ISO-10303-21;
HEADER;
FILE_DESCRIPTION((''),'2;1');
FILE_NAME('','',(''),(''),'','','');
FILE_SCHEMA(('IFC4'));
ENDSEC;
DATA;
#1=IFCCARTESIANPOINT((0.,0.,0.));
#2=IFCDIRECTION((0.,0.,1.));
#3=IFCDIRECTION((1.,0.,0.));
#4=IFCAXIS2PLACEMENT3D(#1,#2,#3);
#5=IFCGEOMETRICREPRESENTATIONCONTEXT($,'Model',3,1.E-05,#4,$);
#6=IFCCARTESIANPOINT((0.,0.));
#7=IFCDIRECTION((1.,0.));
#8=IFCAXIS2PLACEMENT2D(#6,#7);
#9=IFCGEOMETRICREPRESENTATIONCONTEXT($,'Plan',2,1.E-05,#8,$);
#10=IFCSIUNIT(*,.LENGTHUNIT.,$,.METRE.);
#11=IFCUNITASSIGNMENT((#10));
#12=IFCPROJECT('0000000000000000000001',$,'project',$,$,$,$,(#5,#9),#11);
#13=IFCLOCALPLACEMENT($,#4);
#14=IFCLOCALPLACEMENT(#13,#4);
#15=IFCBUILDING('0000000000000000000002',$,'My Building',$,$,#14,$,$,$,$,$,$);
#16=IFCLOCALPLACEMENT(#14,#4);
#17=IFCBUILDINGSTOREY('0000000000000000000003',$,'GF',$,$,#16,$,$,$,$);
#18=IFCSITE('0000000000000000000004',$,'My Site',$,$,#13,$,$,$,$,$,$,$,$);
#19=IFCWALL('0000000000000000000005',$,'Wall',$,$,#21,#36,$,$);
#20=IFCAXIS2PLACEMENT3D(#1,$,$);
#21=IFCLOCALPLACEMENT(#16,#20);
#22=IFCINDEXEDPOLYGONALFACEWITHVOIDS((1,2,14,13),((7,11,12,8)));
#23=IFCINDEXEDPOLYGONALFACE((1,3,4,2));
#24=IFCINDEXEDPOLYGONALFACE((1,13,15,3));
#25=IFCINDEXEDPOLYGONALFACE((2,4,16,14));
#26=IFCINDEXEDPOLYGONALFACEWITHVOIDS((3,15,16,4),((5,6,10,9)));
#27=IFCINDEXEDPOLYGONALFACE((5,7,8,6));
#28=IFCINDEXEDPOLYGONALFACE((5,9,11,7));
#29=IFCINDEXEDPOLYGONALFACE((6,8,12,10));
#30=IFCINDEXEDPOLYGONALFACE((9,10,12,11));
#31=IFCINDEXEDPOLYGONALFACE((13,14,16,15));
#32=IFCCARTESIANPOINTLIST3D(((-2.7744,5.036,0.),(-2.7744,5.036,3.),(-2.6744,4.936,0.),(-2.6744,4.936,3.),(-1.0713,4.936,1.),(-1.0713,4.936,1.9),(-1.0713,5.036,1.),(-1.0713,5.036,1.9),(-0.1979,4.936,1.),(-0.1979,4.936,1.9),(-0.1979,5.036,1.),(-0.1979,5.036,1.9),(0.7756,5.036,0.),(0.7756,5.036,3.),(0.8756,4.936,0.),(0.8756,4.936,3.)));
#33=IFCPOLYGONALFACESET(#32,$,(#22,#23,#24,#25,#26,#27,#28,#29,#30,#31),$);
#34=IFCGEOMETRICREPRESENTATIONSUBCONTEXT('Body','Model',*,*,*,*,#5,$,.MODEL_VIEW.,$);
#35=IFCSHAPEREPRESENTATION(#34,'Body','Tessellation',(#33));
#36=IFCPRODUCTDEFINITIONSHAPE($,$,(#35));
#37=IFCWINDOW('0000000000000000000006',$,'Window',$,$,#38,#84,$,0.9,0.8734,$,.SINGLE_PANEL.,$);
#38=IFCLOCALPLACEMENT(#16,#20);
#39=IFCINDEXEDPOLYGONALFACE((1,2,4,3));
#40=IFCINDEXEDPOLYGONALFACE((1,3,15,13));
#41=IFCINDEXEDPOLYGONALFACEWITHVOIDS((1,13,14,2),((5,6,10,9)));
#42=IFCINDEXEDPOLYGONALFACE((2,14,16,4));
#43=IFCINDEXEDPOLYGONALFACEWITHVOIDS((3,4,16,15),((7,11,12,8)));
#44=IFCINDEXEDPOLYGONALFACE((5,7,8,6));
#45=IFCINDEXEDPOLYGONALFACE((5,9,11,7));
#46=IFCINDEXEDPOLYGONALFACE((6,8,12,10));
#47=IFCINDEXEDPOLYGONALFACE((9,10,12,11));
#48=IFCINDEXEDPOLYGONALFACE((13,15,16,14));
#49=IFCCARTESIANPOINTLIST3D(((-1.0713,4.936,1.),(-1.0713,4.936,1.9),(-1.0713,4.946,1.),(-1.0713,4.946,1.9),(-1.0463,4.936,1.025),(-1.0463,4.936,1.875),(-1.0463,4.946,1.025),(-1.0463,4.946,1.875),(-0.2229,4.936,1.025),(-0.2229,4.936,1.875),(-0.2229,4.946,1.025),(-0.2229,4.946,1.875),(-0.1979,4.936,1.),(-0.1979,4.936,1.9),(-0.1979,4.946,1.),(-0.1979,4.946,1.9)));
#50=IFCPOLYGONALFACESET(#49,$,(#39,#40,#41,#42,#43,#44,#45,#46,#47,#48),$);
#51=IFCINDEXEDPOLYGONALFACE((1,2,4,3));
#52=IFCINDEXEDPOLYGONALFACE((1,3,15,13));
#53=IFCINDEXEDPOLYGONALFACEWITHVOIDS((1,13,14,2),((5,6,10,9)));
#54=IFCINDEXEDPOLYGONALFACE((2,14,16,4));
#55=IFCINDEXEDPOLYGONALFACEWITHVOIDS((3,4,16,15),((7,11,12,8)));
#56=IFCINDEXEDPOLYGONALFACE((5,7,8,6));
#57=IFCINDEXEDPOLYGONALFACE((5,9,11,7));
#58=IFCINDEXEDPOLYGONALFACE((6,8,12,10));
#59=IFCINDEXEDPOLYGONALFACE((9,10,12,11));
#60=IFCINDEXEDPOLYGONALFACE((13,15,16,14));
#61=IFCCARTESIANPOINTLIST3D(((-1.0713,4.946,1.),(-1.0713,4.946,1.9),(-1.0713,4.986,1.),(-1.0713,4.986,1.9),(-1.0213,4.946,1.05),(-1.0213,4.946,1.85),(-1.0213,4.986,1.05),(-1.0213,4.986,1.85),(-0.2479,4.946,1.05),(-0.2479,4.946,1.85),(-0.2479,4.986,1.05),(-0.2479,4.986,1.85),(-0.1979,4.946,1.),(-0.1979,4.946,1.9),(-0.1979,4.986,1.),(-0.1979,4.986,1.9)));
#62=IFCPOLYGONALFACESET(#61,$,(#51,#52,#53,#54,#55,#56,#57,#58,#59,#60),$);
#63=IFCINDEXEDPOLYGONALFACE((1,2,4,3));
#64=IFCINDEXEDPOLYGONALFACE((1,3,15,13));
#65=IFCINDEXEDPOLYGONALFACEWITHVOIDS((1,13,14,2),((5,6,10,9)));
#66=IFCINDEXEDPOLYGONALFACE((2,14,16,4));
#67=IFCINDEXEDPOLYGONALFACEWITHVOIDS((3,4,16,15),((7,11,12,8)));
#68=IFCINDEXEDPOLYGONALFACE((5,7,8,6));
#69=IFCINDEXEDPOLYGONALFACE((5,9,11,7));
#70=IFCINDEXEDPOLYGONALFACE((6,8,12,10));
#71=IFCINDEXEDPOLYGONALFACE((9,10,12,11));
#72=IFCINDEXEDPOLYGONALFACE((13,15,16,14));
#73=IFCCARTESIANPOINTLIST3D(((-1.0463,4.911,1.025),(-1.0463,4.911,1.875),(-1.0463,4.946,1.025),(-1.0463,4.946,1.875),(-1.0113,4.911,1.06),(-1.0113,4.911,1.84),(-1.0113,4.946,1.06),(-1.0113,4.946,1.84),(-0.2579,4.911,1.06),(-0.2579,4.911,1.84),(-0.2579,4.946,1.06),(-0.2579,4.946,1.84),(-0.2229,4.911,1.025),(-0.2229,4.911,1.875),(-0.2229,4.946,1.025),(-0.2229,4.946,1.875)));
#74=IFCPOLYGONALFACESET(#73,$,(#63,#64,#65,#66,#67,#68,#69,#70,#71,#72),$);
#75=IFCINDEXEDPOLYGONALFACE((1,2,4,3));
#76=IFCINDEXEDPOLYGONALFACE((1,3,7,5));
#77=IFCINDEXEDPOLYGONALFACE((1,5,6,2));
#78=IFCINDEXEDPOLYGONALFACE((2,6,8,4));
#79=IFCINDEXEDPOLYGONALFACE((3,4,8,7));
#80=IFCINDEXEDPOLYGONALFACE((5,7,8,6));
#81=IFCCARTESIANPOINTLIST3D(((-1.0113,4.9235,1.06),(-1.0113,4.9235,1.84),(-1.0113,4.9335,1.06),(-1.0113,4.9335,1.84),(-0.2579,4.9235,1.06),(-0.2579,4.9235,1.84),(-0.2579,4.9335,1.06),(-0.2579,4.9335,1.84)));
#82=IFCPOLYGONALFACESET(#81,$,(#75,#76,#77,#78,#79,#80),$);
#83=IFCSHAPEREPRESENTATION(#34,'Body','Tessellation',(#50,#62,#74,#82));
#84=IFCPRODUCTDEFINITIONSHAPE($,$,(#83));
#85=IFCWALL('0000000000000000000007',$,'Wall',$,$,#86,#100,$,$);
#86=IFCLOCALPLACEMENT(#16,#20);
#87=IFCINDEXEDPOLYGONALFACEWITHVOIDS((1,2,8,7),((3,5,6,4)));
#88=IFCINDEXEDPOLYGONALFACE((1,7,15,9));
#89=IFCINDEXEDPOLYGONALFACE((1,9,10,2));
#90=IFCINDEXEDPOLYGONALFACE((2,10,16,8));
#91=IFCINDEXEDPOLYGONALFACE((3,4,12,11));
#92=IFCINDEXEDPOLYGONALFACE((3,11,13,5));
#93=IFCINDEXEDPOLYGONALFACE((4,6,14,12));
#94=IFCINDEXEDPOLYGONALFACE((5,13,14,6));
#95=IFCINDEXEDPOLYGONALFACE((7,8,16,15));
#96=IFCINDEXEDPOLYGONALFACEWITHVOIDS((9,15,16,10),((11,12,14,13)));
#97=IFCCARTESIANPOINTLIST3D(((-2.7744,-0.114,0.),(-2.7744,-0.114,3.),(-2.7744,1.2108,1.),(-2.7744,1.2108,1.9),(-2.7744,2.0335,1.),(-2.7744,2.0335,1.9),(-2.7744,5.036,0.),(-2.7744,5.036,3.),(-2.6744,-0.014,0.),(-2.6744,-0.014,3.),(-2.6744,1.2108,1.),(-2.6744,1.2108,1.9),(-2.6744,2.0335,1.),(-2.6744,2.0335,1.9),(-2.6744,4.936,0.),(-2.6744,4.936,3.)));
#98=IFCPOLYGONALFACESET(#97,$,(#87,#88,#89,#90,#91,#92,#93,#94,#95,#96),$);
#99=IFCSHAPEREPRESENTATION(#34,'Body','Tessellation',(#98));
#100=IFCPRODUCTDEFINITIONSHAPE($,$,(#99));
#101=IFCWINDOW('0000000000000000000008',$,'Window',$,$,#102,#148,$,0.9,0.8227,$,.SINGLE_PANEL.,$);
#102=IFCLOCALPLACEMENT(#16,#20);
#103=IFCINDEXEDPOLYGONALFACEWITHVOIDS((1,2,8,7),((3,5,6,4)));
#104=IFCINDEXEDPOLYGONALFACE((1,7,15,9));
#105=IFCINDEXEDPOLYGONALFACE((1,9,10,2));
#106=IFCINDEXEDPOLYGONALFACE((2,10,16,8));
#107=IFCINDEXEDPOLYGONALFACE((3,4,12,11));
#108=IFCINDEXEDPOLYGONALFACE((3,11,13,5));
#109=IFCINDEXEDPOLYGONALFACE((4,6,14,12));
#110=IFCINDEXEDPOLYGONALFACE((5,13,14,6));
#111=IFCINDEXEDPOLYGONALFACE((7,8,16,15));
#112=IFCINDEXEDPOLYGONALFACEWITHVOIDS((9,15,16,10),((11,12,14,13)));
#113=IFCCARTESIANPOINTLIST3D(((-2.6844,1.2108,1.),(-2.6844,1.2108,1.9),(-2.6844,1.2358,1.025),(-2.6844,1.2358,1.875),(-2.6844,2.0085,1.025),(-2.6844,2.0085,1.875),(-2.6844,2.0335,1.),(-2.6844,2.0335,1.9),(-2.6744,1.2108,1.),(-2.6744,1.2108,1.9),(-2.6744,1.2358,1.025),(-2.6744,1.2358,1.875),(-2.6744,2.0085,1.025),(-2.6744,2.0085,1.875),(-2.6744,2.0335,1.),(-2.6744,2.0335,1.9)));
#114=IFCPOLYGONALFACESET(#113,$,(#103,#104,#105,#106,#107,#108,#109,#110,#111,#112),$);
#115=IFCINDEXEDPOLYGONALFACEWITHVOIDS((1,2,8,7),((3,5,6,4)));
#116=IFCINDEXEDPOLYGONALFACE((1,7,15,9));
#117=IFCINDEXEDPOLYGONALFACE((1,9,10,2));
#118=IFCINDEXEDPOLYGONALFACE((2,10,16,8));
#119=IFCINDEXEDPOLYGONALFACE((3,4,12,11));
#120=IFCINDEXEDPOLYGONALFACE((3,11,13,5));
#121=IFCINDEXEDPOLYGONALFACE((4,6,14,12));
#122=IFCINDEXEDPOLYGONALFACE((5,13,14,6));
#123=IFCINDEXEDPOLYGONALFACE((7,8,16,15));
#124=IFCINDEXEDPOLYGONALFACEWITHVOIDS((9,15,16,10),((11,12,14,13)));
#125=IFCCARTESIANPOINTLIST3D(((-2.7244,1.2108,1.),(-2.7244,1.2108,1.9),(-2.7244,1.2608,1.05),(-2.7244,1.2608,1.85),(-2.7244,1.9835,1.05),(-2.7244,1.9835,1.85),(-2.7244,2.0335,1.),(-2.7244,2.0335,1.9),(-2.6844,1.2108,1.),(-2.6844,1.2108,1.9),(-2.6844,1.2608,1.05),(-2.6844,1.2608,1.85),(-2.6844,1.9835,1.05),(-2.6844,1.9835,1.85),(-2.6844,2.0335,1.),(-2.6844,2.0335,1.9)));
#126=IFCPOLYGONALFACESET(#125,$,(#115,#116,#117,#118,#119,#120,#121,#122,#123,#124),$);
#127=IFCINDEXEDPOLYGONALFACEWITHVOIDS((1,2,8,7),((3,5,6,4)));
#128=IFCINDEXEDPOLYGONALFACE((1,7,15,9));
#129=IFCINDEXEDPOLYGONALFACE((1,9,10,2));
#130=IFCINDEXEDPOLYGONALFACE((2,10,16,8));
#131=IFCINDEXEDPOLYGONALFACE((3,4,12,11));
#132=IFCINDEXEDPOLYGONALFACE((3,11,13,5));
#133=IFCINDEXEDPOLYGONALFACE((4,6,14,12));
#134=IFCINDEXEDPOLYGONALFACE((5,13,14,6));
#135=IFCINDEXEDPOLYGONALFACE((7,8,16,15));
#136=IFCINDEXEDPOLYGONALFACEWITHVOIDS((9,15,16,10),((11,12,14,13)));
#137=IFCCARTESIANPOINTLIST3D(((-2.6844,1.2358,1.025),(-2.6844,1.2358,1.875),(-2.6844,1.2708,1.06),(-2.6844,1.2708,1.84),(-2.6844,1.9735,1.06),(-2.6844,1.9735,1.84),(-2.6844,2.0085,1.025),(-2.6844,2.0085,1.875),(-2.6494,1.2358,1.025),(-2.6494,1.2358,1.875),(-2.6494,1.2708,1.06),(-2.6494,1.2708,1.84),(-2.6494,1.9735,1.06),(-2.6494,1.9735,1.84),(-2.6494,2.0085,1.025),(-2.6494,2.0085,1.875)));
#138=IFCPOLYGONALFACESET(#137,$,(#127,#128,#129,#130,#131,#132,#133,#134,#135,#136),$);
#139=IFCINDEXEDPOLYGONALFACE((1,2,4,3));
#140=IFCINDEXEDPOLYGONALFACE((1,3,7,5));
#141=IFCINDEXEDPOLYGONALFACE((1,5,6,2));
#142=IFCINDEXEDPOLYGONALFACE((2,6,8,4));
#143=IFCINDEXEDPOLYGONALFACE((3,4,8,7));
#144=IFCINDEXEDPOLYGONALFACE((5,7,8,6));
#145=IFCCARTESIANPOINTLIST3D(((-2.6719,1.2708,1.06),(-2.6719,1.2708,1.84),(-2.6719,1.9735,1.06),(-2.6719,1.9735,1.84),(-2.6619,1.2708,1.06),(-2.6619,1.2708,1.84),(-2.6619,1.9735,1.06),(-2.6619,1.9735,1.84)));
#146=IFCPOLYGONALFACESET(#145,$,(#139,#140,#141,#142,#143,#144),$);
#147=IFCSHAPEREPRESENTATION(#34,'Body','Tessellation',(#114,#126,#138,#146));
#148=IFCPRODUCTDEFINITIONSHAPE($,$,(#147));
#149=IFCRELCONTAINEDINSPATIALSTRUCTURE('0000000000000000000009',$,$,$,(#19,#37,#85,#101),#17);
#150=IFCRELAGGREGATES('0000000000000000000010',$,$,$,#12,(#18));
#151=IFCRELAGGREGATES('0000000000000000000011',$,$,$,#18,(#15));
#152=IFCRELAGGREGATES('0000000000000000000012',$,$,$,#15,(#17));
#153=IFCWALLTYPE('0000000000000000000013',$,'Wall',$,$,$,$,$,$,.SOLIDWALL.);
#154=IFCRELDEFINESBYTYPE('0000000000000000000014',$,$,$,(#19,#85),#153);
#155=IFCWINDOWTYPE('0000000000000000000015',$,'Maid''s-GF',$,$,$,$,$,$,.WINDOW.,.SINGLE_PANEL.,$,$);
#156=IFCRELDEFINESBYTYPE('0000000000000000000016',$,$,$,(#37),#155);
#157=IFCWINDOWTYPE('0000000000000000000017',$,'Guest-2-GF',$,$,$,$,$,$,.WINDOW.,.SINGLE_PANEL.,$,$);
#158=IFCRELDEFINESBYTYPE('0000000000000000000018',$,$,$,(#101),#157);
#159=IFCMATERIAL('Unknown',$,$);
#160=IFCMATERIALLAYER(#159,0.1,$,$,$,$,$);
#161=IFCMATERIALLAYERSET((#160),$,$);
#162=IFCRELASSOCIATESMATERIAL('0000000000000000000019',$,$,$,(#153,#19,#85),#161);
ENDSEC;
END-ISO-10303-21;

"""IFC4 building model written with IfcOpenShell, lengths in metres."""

from ifc_helpers import new_model, entity, si_unit, frame, origin_with_axes, origin_2d_with_axis, place, context, subcontext, project, spatial, line, indexed_curve, outline, extrude, shape, source, transform, mapped, material, layer, layer_set, layer_usage, type_object, type_shapes, element, fill, save


model = new_model("IFC4")

# Units and contexts
model_context = context("Model", 3, precision=1e-05, world=origin_with_axes())
plan_context = context("Plan", 2, precision=1e-05, world=origin_2d_with_axis())
body_context_1 = subcontext(model_context, "Body", "Model", "MODEL_VIEW")
body_context_2 = subcontext(plan_context, "Body", "Plan", "PLAN_VIEW")
ifc_project = project(units=[si_unit("LENGTHUNIT", "METRE")], contexts=[model_context, plan_context])

# Site, building, storey
site_placement = place(None, origin_with_axes())
site = spatial("IfcSite", under=ifc_project, at=site_placement, Name="My Site")
building_placement = place(site_placement, origin_with_axes())
building = spatial("IfcBuilding", under=site, at=building_placement, Name="My Building")
storey_placement = place(building_placement, origin_with_axes())
storey = spatial("IfcBuildingStorey", under=building, at=storey_placement, Name="GF")

# Shared definitions
ifc_material_1 = material(Name="Unknown")

# Shared definitions
ifc_layer_1 = layer(ifc_material_1, 0.1)
ifc_layer_set_1 = layer_set([ifc_layer_1])
wall_type = type_object("IfcWallType", Name="Wall", PredefinedType="SOLIDWALL", material=ifc_layer_set_1)

# Walls, openings, windows
ifc_layer_usage_1 = layer_usage(ifc_layer_set_1, "AXIS2", "POSITIVE", 0.0)
wall_1_placement = place(storey_placement, frame((0.7756, 5.036, 0.0), z_axis=(0.0, 0.0, 1.0), x_axis=(-1.0, 0.0, 0.0)))
wall_1 = element("IfcWall", 1, at=wall_1_placement, inside=storey, type_object=wall_type, material=ifc_layer_usage_1, Name="Wall", context=body_context_1, shape_type="SweptSolid", body=[
    extrude(outline(indexed_curve([(0.0, 0.0), (-0.1, 0.1), (3.45, 0.1), (3.55, 0.0)], segments=[line(1, 2, 3, 4, 1)])), origin_with_axes(), (0.0, 0.0, 1.0), 3.0),
])
shared_shape_1 = source(origin_with_axes(), body_context_1, "Body", "SweptSolid", [
    extrude(outline(indexed_curve([(0.0, 0.0), (0.8734, 0.0), (0.8734, 0.9), (0.0, 0.9)], segments=[line(1, 2, 3, 4, 1)])), frame((0.0, -0.6, 0.0), z_axis=(0.0, -1.0, 0.0), x_axis=(1.0, 0.0, 0.0)), (0.0, 0.0, -1.0), 1.2),
])
opening_1_placement = place(wall_1_placement, frame((0.9735, 0.0, 1.0), z_axis=(0.0, 0.0, 1.0), x_axis=(1.0, -0.000001, 0.0)))
opening_1 = element("IfcOpeningElement", 2, at=opening_1_placement, cuts=wall_1, PredefinedType="OPENING", context=body_context_1, shape_type="MappedRepresentation", body=[
    mapped(shared_shape_1, transform((0.0, 0.0, 0.0), x_axis=(1.0, 0.0, 0.0), y_axis=(0.0, 1.0, 0.0), z_axis=(0.0, 0.0, 1.0), scale=1.0)),
])
window_type_1 = type_object("IfcWindowType", Name="Maid's-GF", PartitioningType="SINGLE_PANEL", PredefinedType="WINDOW")
shared_shape_2 = source(origin_with_axes(), body_context_1, "Body", "SweptSolid", [
    extrude(outline(indexed_curve([(0.0, 0.0), (0.8734, 0.0), (0.8734, 0.9), (0.0, 0.9)], segments=[line(1, 2, 3, 4, 1)]), holes=[indexed_curve([(0.025, 0.025), (0.8484, 0.025), (0.8484, 0.875), (0.025, 0.875)], segments=[line(1, 2, 3, 4, 1)])]), frame((0.0, 0.09, 0.0), z_axis=(0.0, -1.0, 0.0), x_axis=(1.0, 0.0, 0.0)), (0.0, 0.0, -1.0), 0.01),
    extrude(outline(indexed_curve([(0.0, 0.0), (0.8734, 0.0), (0.8734, 0.9), (0.0, 0.9)], segments=[line(1, 2, 3, 4, 1)]), holes=[indexed_curve([(0.05, 0.05), (0.8234, 0.05), (0.8234, 0.85), (0.05, 0.85)], segments=[line(1, 2, 3, 4, 1)])]), frame((0.0, 0.05, 0.0), z_axis=(0.0, -1.0, 0.0), x_axis=(1.0, 0.0, 0.0)), (0.0, 0.0, -1.0), 0.04),
    extrude(outline(indexed_curve([(0.0, 0.0), (0.8234, 0.0), (0.8234, 0.85), (0.0, 0.85)], segments=[line(1, 2, 3, 4, 1)]), holes=[indexed_curve([(0.035, 0.035), (0.7884, 0.035), (0.7884, 0.815), (0.035, 0.815)], segments=[line(1, 2, 3, 4, 1)])]), frame((0.025, 0.09, 0.025), z_axis=(0.0, -1.0, 0.0), x_axis=(1.0, 0.0, 0.0)), (0.0, 0.0, -1.0), 0.035),
    extrude(outline(indexed_curve([(0.035, 0.035), (0.7884, 0.035), (0.7884, 0.815), (0.035, 0.815)], segments=[line(1, 2, 3, 4, 1)])), frame((0.025, 0.1025, 0.025), z_axis=(0.0, -1.0, 0.0), x_axis=(1.0, 0.0, 0.0)), (0.0, 0.0, -1.0), 0.01),
])
shared_shape_3 = source(origin_with_axes(), body_context_2, "Body", "Curve2D", [
    entity("IfcIndexedPolyCurve", entity("IfcCartesianPointList2D", [[0.05, 0.05], [0.8234, 0.05]])),
    entity("IfcIndexedPolyCurve", entity("IfcCartesianPointList2D", [[0.0, 0.1], [0.025, 0.1], [0.025, 0.09], [0.05, 0.09], [0.05, 0.05], [0.0, 0.05]]), [entity("IfcLineIndex", [1, 2, 3, 4, 5, 6, 1])]),
    entity("IfcIndexedPolyCurve", entity("IfcCartesianPointList2D", [[0.8734, 0.1], [0.8484, 0.1], [0.8484, 0.09], [0.8234, 0.09], [0.8234, 0.05], [0.8734, 0.05]]), [entity("IfcLineIndex", [1, 2, 3, 4, 5, 6, 1])]),
    entity("IfcIndexedPolyCurve", entity("IfcCartesianPointList2D", [[0.025, 0.09], [0.06, 0.09], [0.06, 0.125], [0.025, 0.125]]), [entity("IfcLineIndex", [1, 2, 3, 4, 1])]),
    entity("IfcIndexedPolyCurve", entity("IfcCartesianPointList2D", [[0.8484, 0.09], [0.8134, 0.09], [0.8134, 0.125], [0.8484, 0.125]]), [entity("IfcLineIndex", [1, 2, 3, 4, 1])]),
    entity("IfcIndexedPolyCurve", entity("IfcCartesianPointList2D", [[0.06, 0.09], [0.8134, 0.09]])),
    entity("IfcIndexedPolyCurve", entity("IfcCartesianPointList2D", [[0.06, 0.125], [0.8134, 0.125]])),
    entity("IfcIndexedPolyCurve", entity("IfcCartesianPointList2D", [[0.06, 0.1075], [0.8134, 0.1075]])),
])
type_shapes(window_type_1, [shared_shape_2, shared_shape_3])
window_1_placement = place(opening_1_placement, frame((0.0, 0.0, 0.0), z_axis=(0.0, 0.0, 1.0), x_axis=(1.0, 0.0, 0.0)))
window_1 = element("IfcWindow", 3, at=window_1_placement, inside=storey, type_object=window_type_1, Name="Window", OverallHeight=0.9, OverallWidth=0.8734, PartitioningType="SINGLE_PANEL", shapes=[
    shape(body_context_1, "Body", "MappedRepresentation", [mapped(shared_shape_2, transform((0.0, 0.0, 0.0), x_axis=(1.0, 0.0, 0.0), y_axis=(0.0, 1.0, 0.0), z_axis=(0.0, 0.0, 1.0), scale=1.0))]),
    shape(body_context_2, "Body", "MappedRepresentation", [mapped(shared_shape_3, transform((0.0, 0.0, 0.0), x_axis=(1.0, 0.0, 0.0), y_axis=(0.0, 1.0, 0.0), z_axis=(0.0, 0.0, 1.0), scale=1.0))]),
])
fill(opening_1, window_1)
ifc_layer_usage_2 = layer_usage(ifc_layer_set_1, "AXIS2", "POSITIVE", 0.0)
wall_2_placement = place(storey_placement, frame((-2.7744, 5.036, 0.0), z_axis=(0.0, 0.0, 1.0), x_axis=(0.0, -1.0, 0.0)))
wall_2 = element("IfcWall", 4, at=wall_2_placement, inside=storey, type_object=wall_type, material=ifc_layer_usage_2, Name="Wall", context=body_context_1, shape_type="SweptSolid", body=[
    extrude(outline(indexed_curve([(0.0, 0.0), (0.1, 0.1), (5.05, 0.1), (5.15, 0.0)], segments=[line(1, 2, 3, 4, 1)])), origin_with_axes(), (0.0, 0.0, 1.0), 3.0),
])
shared_shape_4 = source(origin_with_axes(), body_context_1, "Body", "SweptSolid", [
    extrude(outline(indexed_curve([(0.0, 0.0), (0.8227, 0.0), (0.8227, 0.9), (0.0, 0.9)], segments=[line(1, 2, 3, 4, 1)])), frame((0.0, -0.6, 0.0), z_axis=(0.0, -1.0, 0.0), x_axis=(1.0, 0.0, 0.0)), (0.0, 0.0, -1.0), 1.2),
])
opening_2_placement = place(wall_2_placement, frame((3.0025, 0.0, 1.0), z_axis=(0.0, 0.0, 1.0), x_axis=(1.0, 0.0, 0.0)))
opening_2 = element("IfcOpeningElement", 5, at=opening_2_placement, cuts=wall_2, PredefinedType="OPENING", context=body_context_1, shape_type="MappedRepresentation", body=[
    mapped(shared_shape_4, transform((0.0, 0.0, 0.0), x_axis=(1.0, 0.0, 0.0), y_axis=(0.0, 1.0, 0.0), z_axis=(0.0, 0.0, 1.0), scale=1.0)),
])
window_type_2 = type_object("IfcWindowType", Name="Guest-2-GF", PartitioningType="SINGLE_PANEL", PredefinedType="WINDOW")
shared_shape_5 = source(origin_with_axes(), body_context_1, "Body", "SweptSolid", [
    extrude(outline(indexed_curve([(0.0, 0.0), (0.8227, 0.0), (0.8227, 0.9), (0.0, 0.9)], segments=[line(1, 2, 3, 4, 1)]), holes=[indexed_curve([(0.025, 0.025), (0.7977, 0.025), (0.7977, 0.875), (0.025, 0.875)], segments=[line(1, 2, 3, 4, 1)])]), frame((0.0, 0.09, 0.0), z_axis=(0.0, -1.0, 0.0), x_axis=(1.0, 0.0, 0.0)), (0.0, 0.0, -1.0), 0.01),
    extrude(outline(indexed_curve([(0.0, 0.0), (0.8227, 0.0), (0.8227, 0.9), (0.0, 0.9)], segments=[line(1, 2, 3, 4, 1)]), holes=[indexed_curve([(0.05, 0.05), (0.7727, 0.05), (0.7727, 0.85), (0.05, 0.85)], segments=[line(1, 2, 3, 4, 1)])]), frame((0.0, 0.05, 0.0), z_axis=(0.0, -1.0, 0.0), x_axis=(1.0, 0.0, 0.0)), (0.0, 0.0, -1.0), 0.04),
    extrude(outline(indexed_curve([(0.0, 0.0), (0.7727, 0.0), (0.7727, 0.85), (0.0, 0.85)], segments=[line(1, 2, 3, 4, 1)]), holes=[indexed_curve([(0.035, 0.035), (0.7377, 0.035), (0.7377, 0.815), (0.035, 0.815)], segments=[line(1, 2, 3, 4, 1)])]), frame((0.025, 0.09, 0.025), z_axis=(0.0, -1.0, 0.0), x_axis=(1.0, 0.0, 0.0)), (0.0, 0.0, -1.0), 0.035),
    extrude(outline(indexed_curve([(0.035, 0.035), (0.7377, 0.035), (0.7377, 0.815), (0.035, 0.815)], segments=[line(1, 2, 3, 4, 1)])), frame((0.025, 0.1025, 0.025), z_axis=(0.0, -1.0, 0.0), x_axis=(1.0, 0.0, 0.0)), (0.0, 0.0, -1.0), 0.01),
])
shared_shape_6 = source(origin_with_axes(), body_context_2, "Body", "Curve2D", [
    entity("IfcIndexedPolyCurve", entity("IfcCartesianPointList2D", [[0.05, 0.05], [0.7727, 0.05]])),
    entity("IfcIndexedPolyCurve", entity("IfcCartesianPointList2D", [[0.0, 0.1], [0.025, 0.1], [0.025, 0.09], [0.05, 0.09], [0.05, 0.05], [0.0, 0.05]]), [entity("IfcLineIndex", [1, 2, 3, 4, 5, 6, 1])]),
    entity("IfcIndexedPolyCurve", entity("IfcCartesianPointList2D", [[0.8227, 0.1], [0.7977, 0.1], [0.7977, 0.09], [0.7727, 0.09], [0.7727, 0.05], [0.8227, 0.05]]), [entity("IfcLineIndex", [1, 2, 3, 4, 5, 6, 1])]),
    entity("IfcIndexedPolyCurve", entity("IfcCartesianPointList2D", [[0.025, 0.09], [0.06, 0.09], [0.06, 0.125], [0.025, 0.125]]), [entity("IfcLineIndex", [1, 2, 3, 4, 1])]),
    entity("IfcIndexedPolyCurve", entity("IfcCartesianPointList2D", [[0.7977, 0.09], [0.7627, 0.09], [0.7627, 0.125], [0.7977, 0.125]]), [entity("IfcLineIndex", [1, 2, 3, 4, 1])]),
    entity("IfcIndexedPolyCurve", entity("IfcCartesianPointList2D", [[0.06, 0.09], [0.7627, 0.09]])),
    entity("IfcIndexedPolyCurve", entity("IfcCartesianPointList2D", [[0.06, 0.125], [0.7627, 0.125]])),
    entity("IfcIndexedPolyCurve", entity("IfcCartesianPointList2D", [[0.06, 0.1075], [0.7627, 0.1075]])),
])
type_shapes(window_type_2, [shared_shape_5, shared_shape_6])
window_2_placement = place(opening_2_placement, frame((0.0, 0.0, 0.0), z_axis=(0.0, 0.0, 1.0), x_axis=(1.0, 0.0, 0.0)))
window_2 = element("IfcWindow", 6, at=window_2_placement, inside=storey, type_object=window_type_2, Name="Window", OverallHeight=0.9, OverallWidth=0.8227, PartitioningType="SINGLE_PANEL", shapes=[
    shape(body_context_1, "Body", "MappedRepresentation", [mapped(shared_shape_5, transform((0.0, 0.0, 0.0), x_axis=(1.0, 0.0, 0.0), y_axis=(0.0, 1.0, 0.0), z_axis=(0.0, 0.0, 1.0), scale=1.0))]),
    shape(body_context_2, "Body", "MappedRepresentation", [mapped(shared_shape_6, transform((0.0, 0.0, 0.0), x_axis=(1.0, 0.0, 0.0), y_axis=(0.0, 1.0, 0.0), z_axis=(0.0, 0.0, 1.0), scale=1.0))]),
])
fill(opening_2, window_2)

save(model, "model.ifc")
